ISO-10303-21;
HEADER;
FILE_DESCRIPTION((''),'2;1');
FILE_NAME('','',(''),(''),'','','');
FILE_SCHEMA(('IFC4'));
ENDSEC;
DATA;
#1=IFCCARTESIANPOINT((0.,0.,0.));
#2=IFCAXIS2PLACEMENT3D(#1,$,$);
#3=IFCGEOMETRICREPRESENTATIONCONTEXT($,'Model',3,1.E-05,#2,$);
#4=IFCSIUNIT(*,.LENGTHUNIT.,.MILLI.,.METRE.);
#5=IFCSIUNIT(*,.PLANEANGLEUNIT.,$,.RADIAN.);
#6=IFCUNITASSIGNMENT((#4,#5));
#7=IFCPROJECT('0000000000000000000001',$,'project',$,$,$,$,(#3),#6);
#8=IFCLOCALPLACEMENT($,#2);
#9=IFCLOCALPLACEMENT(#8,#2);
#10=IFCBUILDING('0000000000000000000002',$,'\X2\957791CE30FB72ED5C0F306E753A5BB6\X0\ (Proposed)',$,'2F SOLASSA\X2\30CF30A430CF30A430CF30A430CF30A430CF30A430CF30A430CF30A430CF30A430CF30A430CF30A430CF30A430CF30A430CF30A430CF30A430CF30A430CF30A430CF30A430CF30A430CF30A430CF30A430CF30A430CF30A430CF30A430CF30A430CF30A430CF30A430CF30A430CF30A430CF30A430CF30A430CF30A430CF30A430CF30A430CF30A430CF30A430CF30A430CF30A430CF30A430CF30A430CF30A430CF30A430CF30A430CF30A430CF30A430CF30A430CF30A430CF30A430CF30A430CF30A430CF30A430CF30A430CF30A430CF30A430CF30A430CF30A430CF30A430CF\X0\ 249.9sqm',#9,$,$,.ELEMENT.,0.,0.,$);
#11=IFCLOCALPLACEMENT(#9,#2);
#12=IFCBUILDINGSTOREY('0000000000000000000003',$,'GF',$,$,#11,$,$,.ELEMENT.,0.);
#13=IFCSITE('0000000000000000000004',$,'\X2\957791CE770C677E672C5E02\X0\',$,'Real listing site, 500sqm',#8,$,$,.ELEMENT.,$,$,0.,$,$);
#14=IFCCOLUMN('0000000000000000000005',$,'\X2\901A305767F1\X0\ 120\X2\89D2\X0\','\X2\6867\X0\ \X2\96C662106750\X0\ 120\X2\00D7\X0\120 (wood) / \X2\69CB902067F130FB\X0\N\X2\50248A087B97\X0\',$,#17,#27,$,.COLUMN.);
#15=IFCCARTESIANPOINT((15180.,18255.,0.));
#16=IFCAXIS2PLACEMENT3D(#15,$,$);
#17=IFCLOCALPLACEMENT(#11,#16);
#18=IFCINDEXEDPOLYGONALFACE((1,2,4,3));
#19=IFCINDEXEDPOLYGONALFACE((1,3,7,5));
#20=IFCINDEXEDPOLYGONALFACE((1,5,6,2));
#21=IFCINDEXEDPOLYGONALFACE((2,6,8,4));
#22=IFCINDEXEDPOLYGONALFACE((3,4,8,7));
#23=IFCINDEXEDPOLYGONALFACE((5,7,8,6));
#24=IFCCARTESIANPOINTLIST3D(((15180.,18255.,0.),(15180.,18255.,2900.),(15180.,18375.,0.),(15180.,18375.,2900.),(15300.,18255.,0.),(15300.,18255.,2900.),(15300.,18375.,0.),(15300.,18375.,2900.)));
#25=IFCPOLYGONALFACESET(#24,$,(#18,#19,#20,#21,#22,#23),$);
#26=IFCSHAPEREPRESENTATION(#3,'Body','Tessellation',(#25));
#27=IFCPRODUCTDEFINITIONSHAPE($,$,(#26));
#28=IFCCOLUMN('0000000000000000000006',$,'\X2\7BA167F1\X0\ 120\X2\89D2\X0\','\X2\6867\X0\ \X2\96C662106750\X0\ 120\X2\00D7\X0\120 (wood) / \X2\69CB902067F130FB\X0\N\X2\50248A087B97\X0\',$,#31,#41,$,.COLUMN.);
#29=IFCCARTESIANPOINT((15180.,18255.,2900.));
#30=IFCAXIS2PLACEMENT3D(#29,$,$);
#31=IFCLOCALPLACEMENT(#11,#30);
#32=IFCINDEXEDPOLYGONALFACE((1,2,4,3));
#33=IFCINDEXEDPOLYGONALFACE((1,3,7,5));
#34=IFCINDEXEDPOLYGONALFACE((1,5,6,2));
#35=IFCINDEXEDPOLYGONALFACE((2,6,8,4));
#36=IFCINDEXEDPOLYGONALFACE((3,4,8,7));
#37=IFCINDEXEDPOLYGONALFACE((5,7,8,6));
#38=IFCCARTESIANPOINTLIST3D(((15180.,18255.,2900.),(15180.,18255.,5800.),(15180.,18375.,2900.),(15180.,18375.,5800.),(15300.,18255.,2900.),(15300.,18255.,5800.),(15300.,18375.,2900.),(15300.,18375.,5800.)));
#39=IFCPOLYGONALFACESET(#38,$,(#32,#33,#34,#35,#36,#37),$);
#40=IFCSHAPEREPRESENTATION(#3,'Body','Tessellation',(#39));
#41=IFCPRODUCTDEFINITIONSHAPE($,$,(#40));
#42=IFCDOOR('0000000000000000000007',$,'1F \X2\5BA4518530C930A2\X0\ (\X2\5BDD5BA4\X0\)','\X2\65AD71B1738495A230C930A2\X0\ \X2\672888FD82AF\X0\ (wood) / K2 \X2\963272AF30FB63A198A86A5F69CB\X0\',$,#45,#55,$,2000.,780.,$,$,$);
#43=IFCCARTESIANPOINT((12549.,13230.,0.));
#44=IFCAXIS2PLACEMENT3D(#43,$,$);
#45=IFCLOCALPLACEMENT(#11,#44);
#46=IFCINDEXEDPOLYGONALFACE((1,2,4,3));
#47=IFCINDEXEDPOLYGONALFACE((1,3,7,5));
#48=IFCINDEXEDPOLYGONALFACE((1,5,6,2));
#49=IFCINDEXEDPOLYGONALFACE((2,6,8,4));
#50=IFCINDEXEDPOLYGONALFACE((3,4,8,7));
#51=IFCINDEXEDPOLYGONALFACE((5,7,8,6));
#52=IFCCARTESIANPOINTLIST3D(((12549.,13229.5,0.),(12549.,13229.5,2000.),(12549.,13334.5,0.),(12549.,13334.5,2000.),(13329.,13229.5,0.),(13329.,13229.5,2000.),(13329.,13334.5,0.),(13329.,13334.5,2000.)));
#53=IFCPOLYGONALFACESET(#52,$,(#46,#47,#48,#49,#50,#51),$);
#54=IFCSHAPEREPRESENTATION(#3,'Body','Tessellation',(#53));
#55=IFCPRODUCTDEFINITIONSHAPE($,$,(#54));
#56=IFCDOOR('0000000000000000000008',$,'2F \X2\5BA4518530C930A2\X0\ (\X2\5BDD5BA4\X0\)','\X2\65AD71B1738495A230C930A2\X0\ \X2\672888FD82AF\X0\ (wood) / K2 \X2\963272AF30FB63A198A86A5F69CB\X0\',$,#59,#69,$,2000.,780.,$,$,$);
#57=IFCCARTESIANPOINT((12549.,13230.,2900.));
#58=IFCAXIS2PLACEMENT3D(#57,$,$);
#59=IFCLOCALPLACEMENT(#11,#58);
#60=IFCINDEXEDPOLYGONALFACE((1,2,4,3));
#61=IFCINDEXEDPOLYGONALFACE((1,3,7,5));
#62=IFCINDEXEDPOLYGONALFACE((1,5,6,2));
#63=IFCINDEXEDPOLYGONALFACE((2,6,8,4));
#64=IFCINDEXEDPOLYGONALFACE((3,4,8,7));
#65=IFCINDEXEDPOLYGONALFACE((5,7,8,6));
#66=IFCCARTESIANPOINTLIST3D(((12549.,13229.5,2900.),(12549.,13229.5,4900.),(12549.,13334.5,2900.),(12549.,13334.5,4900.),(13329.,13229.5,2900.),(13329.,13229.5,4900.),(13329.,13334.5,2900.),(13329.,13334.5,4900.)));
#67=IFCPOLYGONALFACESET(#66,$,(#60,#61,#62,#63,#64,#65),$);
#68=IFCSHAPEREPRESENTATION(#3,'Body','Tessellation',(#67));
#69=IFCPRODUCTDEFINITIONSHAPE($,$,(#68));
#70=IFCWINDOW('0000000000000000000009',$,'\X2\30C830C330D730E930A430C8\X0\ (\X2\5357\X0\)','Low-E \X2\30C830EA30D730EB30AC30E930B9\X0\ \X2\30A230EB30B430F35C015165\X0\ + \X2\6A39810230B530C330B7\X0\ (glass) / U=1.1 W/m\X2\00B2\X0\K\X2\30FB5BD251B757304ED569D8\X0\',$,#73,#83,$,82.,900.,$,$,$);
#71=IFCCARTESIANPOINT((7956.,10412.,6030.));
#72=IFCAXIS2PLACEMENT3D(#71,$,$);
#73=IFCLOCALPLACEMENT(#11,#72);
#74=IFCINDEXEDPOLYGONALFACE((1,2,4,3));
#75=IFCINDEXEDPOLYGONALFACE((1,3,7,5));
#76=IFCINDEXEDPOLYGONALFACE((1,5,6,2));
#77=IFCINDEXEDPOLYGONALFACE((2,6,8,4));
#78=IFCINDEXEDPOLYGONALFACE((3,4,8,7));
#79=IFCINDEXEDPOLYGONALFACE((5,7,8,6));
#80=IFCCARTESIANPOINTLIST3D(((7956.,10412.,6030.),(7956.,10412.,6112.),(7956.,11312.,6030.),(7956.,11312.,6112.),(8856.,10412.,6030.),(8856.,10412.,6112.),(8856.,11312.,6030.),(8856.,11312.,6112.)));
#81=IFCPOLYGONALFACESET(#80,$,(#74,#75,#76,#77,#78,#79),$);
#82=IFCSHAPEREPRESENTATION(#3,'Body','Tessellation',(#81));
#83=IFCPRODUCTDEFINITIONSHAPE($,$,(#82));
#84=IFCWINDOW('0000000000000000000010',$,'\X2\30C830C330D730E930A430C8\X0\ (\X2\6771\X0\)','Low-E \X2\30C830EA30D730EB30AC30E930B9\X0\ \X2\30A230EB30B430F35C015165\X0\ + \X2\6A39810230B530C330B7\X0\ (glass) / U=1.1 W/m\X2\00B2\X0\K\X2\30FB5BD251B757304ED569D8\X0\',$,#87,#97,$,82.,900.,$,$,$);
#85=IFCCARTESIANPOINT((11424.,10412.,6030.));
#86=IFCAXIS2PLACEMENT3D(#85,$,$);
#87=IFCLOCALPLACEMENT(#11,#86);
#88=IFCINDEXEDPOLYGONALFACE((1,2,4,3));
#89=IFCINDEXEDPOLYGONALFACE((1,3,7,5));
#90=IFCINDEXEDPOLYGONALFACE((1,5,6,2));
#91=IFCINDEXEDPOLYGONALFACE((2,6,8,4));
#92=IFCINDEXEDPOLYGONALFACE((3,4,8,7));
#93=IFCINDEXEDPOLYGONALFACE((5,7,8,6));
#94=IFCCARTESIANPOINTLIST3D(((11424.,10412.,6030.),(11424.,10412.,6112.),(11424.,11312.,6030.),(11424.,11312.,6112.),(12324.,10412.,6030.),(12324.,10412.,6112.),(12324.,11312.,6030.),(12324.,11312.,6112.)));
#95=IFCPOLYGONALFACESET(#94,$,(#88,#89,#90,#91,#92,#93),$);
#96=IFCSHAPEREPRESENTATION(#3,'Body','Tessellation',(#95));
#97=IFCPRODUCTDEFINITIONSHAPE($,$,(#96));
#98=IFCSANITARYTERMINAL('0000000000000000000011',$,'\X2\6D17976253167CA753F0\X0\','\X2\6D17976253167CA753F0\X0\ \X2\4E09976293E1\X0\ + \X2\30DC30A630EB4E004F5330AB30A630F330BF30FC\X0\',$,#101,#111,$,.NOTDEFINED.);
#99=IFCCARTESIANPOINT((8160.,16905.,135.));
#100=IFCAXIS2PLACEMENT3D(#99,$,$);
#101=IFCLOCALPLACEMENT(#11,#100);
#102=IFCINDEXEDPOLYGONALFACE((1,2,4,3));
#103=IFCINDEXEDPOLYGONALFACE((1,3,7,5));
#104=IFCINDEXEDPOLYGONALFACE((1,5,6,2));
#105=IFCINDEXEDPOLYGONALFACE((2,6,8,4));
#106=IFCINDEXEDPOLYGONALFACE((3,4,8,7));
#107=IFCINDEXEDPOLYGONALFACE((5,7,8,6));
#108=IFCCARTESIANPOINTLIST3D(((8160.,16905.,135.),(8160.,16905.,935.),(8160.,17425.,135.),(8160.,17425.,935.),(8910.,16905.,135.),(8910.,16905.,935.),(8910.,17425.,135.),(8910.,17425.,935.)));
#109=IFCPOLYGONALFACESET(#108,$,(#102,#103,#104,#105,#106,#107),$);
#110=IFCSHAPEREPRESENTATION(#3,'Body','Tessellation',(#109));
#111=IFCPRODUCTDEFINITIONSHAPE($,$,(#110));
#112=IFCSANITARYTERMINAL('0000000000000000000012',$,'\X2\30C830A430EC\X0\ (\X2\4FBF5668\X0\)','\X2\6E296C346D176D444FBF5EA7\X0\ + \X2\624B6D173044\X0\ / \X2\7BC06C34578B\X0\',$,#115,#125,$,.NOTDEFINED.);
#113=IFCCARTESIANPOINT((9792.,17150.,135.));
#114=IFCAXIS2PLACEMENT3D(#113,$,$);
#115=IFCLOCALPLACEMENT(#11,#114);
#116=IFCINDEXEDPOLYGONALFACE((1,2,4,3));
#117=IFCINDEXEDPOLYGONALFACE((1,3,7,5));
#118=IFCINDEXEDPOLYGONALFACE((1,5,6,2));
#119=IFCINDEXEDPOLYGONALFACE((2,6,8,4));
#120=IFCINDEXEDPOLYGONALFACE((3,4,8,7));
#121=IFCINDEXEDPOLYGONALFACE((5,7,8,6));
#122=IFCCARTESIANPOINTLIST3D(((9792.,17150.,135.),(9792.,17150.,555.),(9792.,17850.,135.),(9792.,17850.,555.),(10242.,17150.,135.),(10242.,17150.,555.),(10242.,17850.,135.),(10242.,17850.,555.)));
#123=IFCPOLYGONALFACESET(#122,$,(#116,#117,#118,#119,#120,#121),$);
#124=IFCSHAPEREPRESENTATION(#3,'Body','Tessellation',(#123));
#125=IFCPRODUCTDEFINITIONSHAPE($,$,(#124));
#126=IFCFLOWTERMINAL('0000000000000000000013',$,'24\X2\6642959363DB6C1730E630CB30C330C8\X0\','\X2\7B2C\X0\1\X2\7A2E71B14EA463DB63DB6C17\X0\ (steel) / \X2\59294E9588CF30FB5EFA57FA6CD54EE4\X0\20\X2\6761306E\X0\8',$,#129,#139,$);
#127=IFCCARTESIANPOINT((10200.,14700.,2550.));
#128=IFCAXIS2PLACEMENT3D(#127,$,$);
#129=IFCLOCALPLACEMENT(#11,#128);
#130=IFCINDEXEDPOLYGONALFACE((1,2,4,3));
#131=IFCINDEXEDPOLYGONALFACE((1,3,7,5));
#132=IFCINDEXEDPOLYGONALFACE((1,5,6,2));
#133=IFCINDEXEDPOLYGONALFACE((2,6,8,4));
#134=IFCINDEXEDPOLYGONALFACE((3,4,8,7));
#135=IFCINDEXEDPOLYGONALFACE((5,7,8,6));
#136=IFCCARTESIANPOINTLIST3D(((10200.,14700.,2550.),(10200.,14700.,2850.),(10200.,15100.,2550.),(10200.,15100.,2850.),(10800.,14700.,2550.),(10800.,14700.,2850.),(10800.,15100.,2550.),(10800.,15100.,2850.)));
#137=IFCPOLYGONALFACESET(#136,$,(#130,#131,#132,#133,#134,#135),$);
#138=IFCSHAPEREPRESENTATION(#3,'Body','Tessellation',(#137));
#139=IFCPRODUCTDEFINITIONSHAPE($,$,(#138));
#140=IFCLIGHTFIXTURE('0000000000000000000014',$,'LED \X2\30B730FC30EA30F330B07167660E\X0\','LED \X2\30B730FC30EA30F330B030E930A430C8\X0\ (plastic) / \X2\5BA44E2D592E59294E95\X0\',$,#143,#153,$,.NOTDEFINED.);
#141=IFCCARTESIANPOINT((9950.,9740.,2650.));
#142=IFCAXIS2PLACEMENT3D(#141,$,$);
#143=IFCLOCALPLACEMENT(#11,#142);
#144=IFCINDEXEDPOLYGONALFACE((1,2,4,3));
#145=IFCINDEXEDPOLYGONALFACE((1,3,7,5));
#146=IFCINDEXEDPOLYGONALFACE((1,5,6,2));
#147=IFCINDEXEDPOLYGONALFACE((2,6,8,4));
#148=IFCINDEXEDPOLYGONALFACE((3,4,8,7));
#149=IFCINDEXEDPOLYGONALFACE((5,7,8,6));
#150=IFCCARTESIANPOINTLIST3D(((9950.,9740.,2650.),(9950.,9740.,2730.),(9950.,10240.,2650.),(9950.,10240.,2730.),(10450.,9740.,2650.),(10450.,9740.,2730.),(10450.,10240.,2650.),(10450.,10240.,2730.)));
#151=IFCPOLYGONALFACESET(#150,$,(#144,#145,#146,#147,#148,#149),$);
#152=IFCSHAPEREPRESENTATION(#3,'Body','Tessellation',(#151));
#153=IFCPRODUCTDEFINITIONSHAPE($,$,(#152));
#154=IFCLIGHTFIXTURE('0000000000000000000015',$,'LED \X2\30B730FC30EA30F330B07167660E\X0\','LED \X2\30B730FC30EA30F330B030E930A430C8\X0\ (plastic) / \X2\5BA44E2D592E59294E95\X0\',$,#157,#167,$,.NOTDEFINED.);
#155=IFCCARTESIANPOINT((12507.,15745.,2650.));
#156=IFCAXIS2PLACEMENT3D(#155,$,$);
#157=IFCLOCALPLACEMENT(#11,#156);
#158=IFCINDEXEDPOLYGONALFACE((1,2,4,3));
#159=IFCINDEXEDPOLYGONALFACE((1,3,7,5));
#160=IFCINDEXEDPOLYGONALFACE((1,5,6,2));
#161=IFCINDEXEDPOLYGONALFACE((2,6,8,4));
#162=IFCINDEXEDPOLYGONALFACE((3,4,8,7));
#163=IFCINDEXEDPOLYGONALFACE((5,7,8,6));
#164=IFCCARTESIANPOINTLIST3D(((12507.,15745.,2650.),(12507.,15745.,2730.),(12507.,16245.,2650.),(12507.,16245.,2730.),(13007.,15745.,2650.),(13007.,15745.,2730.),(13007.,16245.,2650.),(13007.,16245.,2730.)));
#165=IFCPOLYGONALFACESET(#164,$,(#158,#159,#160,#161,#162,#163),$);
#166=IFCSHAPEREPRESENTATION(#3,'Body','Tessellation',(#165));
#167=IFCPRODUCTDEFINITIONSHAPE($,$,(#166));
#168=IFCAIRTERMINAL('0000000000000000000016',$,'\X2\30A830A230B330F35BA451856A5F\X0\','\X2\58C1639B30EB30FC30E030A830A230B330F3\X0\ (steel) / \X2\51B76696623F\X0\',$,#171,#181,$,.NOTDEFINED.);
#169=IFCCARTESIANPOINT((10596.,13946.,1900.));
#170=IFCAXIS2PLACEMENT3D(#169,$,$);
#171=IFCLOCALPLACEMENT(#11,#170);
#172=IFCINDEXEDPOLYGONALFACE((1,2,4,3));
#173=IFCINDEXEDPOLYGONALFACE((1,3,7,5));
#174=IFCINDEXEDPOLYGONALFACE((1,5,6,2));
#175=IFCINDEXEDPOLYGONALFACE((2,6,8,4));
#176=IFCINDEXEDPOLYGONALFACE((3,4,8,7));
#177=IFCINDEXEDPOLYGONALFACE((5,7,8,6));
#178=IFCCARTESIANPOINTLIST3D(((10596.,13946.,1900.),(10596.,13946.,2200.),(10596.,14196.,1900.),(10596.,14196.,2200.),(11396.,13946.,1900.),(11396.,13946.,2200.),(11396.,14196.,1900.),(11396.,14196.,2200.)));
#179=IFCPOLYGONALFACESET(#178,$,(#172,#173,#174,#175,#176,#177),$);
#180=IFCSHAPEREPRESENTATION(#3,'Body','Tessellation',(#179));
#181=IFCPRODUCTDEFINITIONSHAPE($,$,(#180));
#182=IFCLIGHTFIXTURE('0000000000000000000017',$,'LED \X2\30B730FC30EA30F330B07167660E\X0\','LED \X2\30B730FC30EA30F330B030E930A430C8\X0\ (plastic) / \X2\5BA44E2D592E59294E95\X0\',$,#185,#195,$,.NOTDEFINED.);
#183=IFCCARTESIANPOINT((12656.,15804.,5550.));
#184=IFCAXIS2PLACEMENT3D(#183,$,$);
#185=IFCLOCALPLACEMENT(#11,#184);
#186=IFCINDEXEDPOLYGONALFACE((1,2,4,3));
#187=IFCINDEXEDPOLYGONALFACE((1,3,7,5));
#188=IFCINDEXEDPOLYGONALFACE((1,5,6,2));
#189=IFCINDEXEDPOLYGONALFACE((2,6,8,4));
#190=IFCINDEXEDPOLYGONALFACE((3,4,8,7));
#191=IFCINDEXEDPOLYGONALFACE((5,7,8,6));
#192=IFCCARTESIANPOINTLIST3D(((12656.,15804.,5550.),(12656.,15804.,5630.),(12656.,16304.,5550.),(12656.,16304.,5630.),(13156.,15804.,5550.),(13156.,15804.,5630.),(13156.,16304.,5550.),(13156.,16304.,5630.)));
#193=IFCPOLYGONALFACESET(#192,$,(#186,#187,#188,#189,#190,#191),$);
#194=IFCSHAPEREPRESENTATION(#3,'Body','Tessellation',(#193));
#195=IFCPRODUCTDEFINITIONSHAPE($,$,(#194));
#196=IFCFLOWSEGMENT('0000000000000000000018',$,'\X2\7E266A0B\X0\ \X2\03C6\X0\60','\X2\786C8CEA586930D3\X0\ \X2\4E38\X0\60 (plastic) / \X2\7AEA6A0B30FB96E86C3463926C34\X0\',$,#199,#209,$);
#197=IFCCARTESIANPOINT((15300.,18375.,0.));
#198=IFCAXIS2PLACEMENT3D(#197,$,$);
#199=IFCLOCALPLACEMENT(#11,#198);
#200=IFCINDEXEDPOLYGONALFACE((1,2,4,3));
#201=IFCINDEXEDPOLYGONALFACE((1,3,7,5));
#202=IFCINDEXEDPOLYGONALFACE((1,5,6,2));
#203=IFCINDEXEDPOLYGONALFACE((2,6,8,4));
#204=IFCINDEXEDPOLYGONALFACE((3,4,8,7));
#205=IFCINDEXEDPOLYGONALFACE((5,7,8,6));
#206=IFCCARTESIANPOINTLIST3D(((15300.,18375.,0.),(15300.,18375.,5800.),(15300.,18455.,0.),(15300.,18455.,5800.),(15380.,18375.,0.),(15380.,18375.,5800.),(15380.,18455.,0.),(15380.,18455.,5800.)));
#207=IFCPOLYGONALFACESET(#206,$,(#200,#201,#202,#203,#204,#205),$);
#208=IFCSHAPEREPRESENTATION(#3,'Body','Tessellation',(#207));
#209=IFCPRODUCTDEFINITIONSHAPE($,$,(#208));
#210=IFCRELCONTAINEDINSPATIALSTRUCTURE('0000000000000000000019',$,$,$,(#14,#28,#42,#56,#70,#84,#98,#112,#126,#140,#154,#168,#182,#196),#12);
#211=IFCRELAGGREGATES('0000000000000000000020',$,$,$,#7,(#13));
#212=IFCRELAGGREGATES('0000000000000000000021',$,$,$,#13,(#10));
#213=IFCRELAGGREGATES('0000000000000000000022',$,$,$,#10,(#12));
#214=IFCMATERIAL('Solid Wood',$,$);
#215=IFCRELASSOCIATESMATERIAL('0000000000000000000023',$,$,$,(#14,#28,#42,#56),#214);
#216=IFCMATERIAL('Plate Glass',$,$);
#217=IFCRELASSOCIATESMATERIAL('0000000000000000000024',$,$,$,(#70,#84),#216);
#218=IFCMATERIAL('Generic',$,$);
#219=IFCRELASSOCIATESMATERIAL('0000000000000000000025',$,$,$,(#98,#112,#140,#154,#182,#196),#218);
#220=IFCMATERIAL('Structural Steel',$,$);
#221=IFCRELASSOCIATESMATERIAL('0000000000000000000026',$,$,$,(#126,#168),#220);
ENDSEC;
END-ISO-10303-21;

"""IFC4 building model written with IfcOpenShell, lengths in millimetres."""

from ifc_helpers import new_model, si_unit, frame, frame_2d, origin, place, context, project, spatial, rectangle, extrude, material, element, save


model = new_model("IFC4")

# Units and contexts
model_context = context("Model", 3, precision=1e-05, world=origin())
ifc_project = project(units=[si_unit("LENGTHUNIT", "METRE", prefix="MILLI"), si_unit("PLANEANGLEUNIT", "RADIAN")], contexts=[model_context])

# Site, building, storey
site_placement = place(None, origin())
site = spatial("IfcSite", under=ifc_project, at=site_placement, Name="長野県松本市", ObjectType="Real listing site, 500sqm", CompositionType="ELEMENT", RefElevation=0.0)
building_placement = place(site_placement, origin())
building = spatial("IfcBuilding", under=site, at=building_placement, Name="長野・狭小の町家 (Proposed)", ObjectType="2F SOLASSAハイハイハイハイハイハイハイハイハイハイハイハイハイハイハイハイハイハイハイハイハイハイハイハイハイハイハイハイハイハイハイハイハイハイハイハイハイハイハイハイハイハイハイハイハイハイハイハイハイハイハイハイハイハイハイハイハ 249.9sqm", CompositionType="ELEMENT", ElevationOfRefHeight=0.0, ElevationOfTerrain=0.0)
storey_placement = place(building_placement, origin())
storey = spatial("IfcBuildingStorey", under=building, at=storey_placement, Name="GF", CompositionType="ELEMENT", Elevation=0.0)

# Columns
ifc_material_1 = material(Name="Solid Wood")
column_1_placement = place(storey_placement, frame((15180.0, 18255.0, 0.0)))
element("IfcColumn", 1, at=column_1_placement, inside=storey, material=ifc_material_1, Name="通し柱 120角", Description="桧 集成材 120×120 (wood) / 構造柱・N値計算", PredefinedType="COLUMN", context=model_context, shape_type="SweptSolid", body=[
    extrude(rectangle(XDim=120.0, YDim=120.0, at=frame_2d((60.0, 60.0))), frame((15180.0, 18255.0, 0.0)), (0.0, 0.0, 1.0), 2900.0),
])
column_2_placement = place(storey_placement, frame((15180.0, 18255.0, 2900.0)))
element("IfcColumn", 2, at=column_2_placement, inside=storey, material=ifc_material_1, Name="管柱 120角", Description="桧 集成材 120×120 (wood) / 構造柱・N値計算", PredefinedType="COLUMN", context=model_context, shape_type="SweptSolid", body=[
    extrude(rectangle(XDim=120.0, YDim=120.0, at=frame_2d((60.0, 60.0))), frame((15180.0, 18255.0, 2900.0)), (0.0, 0.0, 1.0), 2900.0),
])

# Door
door_1_placement = place(storey_placement, frame((12549.0, 13230.0, 0.0)))
element("IfcDoor", 3, at=door_1_placement, inside=storey, material=ifc_material_1, Name="1F 室内ドア (寝室)", Description="断熱玄関ドア 木製芯 (wood) / K2 防犯・採風機構", OverallHeight=2000.0, OverallWidth=780.0, context=model_context, shape_type="SweptSolid", body=[
    extrude(rectangle(XDim=780.0, YDim=105.0, at=frame_2d((390.0, 52.0))), frame((12549.0, 13230.0, 0.0)), (0.0, 0.0, 1.0), 2000.0),
])

# Door
door_2_placement = place(storey_placement, frame((12549.0, 13230.0, 2900.0)))
element("IfcDoor", 4, at=door_2_placement, inside=storey, material=ifc_material_1, Name="2F 室内ドア (寝室)", Description="断熱玄関ドア 木製芯 (wood) / K2 防犯・採風機構", OverallHeight=2000.0, OverallWidth=780.0, context=model_context, shape_type="SweptSolid", body=[
    extrude(rectangle(XDim=780.0, YDim=105.0, at=frame_2d((390.0, 52.0))), frame((12549.0, 13230.0, 2900.0)), (0.0, 0.0, 1.0), 2000.0),
])

# Windows
ifc_material_2 = material(Name="Plate Glass")
window_1_placement = place(storey_placement, frame((7956.0, 10412.0, 6030.0)))
element("IfcWindow", 5, at=window_1_placement, inside=storey, material=ifc_material_2, Name="トップライト (南)", Description="Low-E トリプルガラス アルゴン封入 + 樹脂サッシ (glass) / U=1.1 W/m²K・寒冷地仕様", OverallHeight=82.0, OverallWidth=900.0, context=model_context, shape_type="SweptSolid", body=[
    extrude(rectangle(XDim=900.0, YDim=900.0, at=frame_2d((450.0, 450.0))), frame((7956.0, 10412.0, 6030.0)), (0.0, 0.0, 1.0), 82.0),
])
window_2_placement = place(storey_placement, frame((11424.0, 10412.0, 6030.0)))
element("IfcWindow", 6, at=window_2_placement, inside=storey, material=ifc_material_2, Name="トップライト (東)", Description="Low-E トリプルガラス アルゴン封入 + 樹脂サッシ (glass) / U=1.1 W/m²K・寒冷地仕様", OverallHeight=82.0, OverallWidth=900.0, context=model_context, shape_type="SweptSolid", body=[
    extrude(rectangle(XDim=900.0, YDim=900.0, at=frame_2d((450.0, 450.0))), frame((11424.0, 10412.0, 6030.0)), (0.0, 0.0, 1.0), 82.0),
])

# Sanitary terminals
ifc_material_3 = material(Name="Generic")
sanitary_terminal_1_placement = place(storey_placement, frame((8160.0, 16905.0, 135.0)))
element("IfcSanitaryTerminal", 7, at=sanitary_terminal_1_placement, inside=storey, material=ifc_material_3, Name="洗面化粧台", Description="洗面化粧台 三面鏡 + ボウル一体カウンター", PredefinedType="NOTDEFINED", context=model_context, shape_type="SweptSolid", body=[
    extrude(rectangle(XDim=750.0, YDim=520.0, at=frame_2d((375.0, 260.0))), frame((8160.0, 16905.0, 135.0)), (0.0, 0.0, 1.0), 800.0),
])
sanitary_terminal_2_placement = place(storey_placement, frame((9792.0, 17150.0, 135.0)))
element("IfcSanitaryTerminal", 8, at=sanitary_terminal_2_placement, inside=storey, material=ifc_material_3, Name="トイレ (便器)", Description="温水洗浄便座 + 手洗い / 節水型", PredefinedType="NOTDEFINED", context=model_context, shape_type="SweptSolid", body=[
    extrude(rectangle(XDim=450.0, YDim=700.0, at=frame_2d((225.0, 350.0))), frame((9792.0, 17150.0, 135.0)), (0.0, 0.0, 1.0), 420.0),
])

# Flow terminal
ifc_material_4 = material(Name="Structural Steel")
flow_terminal_placement = place(storey_placement, frame((10200.0, 14700.0, 2550.0)))
element("IfcFlowTerminal", 9, at=flow_terminal_placement, inside=storey, material=ifc_material_4, Name="24時間換気ユニット", Description="第1種熱交換換気 (steel) / 天井裏・建基法令20条の8", context=model_context, shape_type="SweptSolid", body=[
    extrude(rectangle(XDim=600.0, YDim=400.0, at=frame_2d((300.0, 200.0))), frame((10200.0, 14700.0, 2550.0)), (0.0, 0.0, 1.0), 300.0),
])

# Light fixtures
light_fixture_1_placement = place(storey_placement, frame((9950.0, 9740.0, 2650.0)))
element("IfcLightFixture", 10, at=light_fixture_1_placement, inside=storey, material=ifc_material_3, Name="LED シーリング照明", Description="LED シーリングライト (plastic) / 室中央天井", PredefinedType="NOTDEFINED", context=model_context, shape_type="SweptSolid", body=[
    extrude(rectangle(XDim=500.0, YDim=500.0, at=frame_2d((250.0, 250.0))), frame((9950.0, 9740.0, 2650.0)), (0.0, 0.0, 1.0), 80.0),
])
light_fixture_2_placement = place(storey_placement, frame((12507.0, 15745.0, 2650.0)))
element("IfcLightFixture", 11, at=light_fixture_2_placement, inside=storey, material=ifc_material_3, Name="LED シーリング照明", Description="LED シーリングライト (plastic) / 室中央天井", PredefinedType="NOTDEFINED", context=model_context, shape_type="SweptSolid", body=[
    extrude(rectangle(XDim=500.0, YDim=500.0, at=frame_2d((250.0, 250.0))), frame((12507.0, 15745.0, 2650.0)), (0.0, 0.0, 1.0), 80.0),
])

# Air terminal
air_terminal_placement = place(storey_placement, frame((10596.0, 13946.0, 1900.0)))
element("IfcAirTerminal", 12, at=air_terminal_placement, inside=storey, material=ifc_material_4, Name="エアコン室内機", Description="壁掛ルームエアコン (steel) / 冷暖房", PredefinedType="NOTDEFINED", context=model_context, shape_type="SweptSolid", body=[
    extrude(rectangle(XDim=800.0, YDim=250.0, at=frame_2d((400.0, 125.0))), frame((10596.0, 13946.0, 1900.0)), (0.0, 0.0, 1.0), 300.0),
])

# Light fixture
light_fixture_3_placement = place(storey_placement, frame((12656.0, 15804.0, 5550.0)))
element("IfcLightFixture", 13, at=light_fixture_3_placement, inside=storey, material=ifc_material_3, Name="LED シーリング照明", Description="LED シーリングライト (plastic) / 室中央天井", PredefinedType="NOTDEFINED", context=model_context, shape_type="SweptSolid", body=[
    extrude(rectangle(XDim=500.0, YDim=500.0, at=frame_2d((250.0, 250.0))), frame((12656.0, 15804.0, 5550.0)), (0.0, 0.0, 1.0), 80.0),
])

# Flow segment
flow_segment_placement = place(storey_placement, frame((15300.0, 18375.0, 0.0)))
element("IfcFlowSegment", 14, at=flow_segment_placement, inside=storey, material=ifc_material_3, Name="縦樋 φ60", Description="硬質塩ビ 丸60 (plastic) / 竪樋・雨水排水", context=model_context, shape_type="SweptSolid", body=[
    extrude(rectangle(XDim=80.0, YDim=80.0, at=frame_2d((40.0, 40.0))), frame((15300.0, 18375.0, 0.0)), (0.0, 0.0, 1.0), 5800.0),
])

save(model, "model.ifc")
